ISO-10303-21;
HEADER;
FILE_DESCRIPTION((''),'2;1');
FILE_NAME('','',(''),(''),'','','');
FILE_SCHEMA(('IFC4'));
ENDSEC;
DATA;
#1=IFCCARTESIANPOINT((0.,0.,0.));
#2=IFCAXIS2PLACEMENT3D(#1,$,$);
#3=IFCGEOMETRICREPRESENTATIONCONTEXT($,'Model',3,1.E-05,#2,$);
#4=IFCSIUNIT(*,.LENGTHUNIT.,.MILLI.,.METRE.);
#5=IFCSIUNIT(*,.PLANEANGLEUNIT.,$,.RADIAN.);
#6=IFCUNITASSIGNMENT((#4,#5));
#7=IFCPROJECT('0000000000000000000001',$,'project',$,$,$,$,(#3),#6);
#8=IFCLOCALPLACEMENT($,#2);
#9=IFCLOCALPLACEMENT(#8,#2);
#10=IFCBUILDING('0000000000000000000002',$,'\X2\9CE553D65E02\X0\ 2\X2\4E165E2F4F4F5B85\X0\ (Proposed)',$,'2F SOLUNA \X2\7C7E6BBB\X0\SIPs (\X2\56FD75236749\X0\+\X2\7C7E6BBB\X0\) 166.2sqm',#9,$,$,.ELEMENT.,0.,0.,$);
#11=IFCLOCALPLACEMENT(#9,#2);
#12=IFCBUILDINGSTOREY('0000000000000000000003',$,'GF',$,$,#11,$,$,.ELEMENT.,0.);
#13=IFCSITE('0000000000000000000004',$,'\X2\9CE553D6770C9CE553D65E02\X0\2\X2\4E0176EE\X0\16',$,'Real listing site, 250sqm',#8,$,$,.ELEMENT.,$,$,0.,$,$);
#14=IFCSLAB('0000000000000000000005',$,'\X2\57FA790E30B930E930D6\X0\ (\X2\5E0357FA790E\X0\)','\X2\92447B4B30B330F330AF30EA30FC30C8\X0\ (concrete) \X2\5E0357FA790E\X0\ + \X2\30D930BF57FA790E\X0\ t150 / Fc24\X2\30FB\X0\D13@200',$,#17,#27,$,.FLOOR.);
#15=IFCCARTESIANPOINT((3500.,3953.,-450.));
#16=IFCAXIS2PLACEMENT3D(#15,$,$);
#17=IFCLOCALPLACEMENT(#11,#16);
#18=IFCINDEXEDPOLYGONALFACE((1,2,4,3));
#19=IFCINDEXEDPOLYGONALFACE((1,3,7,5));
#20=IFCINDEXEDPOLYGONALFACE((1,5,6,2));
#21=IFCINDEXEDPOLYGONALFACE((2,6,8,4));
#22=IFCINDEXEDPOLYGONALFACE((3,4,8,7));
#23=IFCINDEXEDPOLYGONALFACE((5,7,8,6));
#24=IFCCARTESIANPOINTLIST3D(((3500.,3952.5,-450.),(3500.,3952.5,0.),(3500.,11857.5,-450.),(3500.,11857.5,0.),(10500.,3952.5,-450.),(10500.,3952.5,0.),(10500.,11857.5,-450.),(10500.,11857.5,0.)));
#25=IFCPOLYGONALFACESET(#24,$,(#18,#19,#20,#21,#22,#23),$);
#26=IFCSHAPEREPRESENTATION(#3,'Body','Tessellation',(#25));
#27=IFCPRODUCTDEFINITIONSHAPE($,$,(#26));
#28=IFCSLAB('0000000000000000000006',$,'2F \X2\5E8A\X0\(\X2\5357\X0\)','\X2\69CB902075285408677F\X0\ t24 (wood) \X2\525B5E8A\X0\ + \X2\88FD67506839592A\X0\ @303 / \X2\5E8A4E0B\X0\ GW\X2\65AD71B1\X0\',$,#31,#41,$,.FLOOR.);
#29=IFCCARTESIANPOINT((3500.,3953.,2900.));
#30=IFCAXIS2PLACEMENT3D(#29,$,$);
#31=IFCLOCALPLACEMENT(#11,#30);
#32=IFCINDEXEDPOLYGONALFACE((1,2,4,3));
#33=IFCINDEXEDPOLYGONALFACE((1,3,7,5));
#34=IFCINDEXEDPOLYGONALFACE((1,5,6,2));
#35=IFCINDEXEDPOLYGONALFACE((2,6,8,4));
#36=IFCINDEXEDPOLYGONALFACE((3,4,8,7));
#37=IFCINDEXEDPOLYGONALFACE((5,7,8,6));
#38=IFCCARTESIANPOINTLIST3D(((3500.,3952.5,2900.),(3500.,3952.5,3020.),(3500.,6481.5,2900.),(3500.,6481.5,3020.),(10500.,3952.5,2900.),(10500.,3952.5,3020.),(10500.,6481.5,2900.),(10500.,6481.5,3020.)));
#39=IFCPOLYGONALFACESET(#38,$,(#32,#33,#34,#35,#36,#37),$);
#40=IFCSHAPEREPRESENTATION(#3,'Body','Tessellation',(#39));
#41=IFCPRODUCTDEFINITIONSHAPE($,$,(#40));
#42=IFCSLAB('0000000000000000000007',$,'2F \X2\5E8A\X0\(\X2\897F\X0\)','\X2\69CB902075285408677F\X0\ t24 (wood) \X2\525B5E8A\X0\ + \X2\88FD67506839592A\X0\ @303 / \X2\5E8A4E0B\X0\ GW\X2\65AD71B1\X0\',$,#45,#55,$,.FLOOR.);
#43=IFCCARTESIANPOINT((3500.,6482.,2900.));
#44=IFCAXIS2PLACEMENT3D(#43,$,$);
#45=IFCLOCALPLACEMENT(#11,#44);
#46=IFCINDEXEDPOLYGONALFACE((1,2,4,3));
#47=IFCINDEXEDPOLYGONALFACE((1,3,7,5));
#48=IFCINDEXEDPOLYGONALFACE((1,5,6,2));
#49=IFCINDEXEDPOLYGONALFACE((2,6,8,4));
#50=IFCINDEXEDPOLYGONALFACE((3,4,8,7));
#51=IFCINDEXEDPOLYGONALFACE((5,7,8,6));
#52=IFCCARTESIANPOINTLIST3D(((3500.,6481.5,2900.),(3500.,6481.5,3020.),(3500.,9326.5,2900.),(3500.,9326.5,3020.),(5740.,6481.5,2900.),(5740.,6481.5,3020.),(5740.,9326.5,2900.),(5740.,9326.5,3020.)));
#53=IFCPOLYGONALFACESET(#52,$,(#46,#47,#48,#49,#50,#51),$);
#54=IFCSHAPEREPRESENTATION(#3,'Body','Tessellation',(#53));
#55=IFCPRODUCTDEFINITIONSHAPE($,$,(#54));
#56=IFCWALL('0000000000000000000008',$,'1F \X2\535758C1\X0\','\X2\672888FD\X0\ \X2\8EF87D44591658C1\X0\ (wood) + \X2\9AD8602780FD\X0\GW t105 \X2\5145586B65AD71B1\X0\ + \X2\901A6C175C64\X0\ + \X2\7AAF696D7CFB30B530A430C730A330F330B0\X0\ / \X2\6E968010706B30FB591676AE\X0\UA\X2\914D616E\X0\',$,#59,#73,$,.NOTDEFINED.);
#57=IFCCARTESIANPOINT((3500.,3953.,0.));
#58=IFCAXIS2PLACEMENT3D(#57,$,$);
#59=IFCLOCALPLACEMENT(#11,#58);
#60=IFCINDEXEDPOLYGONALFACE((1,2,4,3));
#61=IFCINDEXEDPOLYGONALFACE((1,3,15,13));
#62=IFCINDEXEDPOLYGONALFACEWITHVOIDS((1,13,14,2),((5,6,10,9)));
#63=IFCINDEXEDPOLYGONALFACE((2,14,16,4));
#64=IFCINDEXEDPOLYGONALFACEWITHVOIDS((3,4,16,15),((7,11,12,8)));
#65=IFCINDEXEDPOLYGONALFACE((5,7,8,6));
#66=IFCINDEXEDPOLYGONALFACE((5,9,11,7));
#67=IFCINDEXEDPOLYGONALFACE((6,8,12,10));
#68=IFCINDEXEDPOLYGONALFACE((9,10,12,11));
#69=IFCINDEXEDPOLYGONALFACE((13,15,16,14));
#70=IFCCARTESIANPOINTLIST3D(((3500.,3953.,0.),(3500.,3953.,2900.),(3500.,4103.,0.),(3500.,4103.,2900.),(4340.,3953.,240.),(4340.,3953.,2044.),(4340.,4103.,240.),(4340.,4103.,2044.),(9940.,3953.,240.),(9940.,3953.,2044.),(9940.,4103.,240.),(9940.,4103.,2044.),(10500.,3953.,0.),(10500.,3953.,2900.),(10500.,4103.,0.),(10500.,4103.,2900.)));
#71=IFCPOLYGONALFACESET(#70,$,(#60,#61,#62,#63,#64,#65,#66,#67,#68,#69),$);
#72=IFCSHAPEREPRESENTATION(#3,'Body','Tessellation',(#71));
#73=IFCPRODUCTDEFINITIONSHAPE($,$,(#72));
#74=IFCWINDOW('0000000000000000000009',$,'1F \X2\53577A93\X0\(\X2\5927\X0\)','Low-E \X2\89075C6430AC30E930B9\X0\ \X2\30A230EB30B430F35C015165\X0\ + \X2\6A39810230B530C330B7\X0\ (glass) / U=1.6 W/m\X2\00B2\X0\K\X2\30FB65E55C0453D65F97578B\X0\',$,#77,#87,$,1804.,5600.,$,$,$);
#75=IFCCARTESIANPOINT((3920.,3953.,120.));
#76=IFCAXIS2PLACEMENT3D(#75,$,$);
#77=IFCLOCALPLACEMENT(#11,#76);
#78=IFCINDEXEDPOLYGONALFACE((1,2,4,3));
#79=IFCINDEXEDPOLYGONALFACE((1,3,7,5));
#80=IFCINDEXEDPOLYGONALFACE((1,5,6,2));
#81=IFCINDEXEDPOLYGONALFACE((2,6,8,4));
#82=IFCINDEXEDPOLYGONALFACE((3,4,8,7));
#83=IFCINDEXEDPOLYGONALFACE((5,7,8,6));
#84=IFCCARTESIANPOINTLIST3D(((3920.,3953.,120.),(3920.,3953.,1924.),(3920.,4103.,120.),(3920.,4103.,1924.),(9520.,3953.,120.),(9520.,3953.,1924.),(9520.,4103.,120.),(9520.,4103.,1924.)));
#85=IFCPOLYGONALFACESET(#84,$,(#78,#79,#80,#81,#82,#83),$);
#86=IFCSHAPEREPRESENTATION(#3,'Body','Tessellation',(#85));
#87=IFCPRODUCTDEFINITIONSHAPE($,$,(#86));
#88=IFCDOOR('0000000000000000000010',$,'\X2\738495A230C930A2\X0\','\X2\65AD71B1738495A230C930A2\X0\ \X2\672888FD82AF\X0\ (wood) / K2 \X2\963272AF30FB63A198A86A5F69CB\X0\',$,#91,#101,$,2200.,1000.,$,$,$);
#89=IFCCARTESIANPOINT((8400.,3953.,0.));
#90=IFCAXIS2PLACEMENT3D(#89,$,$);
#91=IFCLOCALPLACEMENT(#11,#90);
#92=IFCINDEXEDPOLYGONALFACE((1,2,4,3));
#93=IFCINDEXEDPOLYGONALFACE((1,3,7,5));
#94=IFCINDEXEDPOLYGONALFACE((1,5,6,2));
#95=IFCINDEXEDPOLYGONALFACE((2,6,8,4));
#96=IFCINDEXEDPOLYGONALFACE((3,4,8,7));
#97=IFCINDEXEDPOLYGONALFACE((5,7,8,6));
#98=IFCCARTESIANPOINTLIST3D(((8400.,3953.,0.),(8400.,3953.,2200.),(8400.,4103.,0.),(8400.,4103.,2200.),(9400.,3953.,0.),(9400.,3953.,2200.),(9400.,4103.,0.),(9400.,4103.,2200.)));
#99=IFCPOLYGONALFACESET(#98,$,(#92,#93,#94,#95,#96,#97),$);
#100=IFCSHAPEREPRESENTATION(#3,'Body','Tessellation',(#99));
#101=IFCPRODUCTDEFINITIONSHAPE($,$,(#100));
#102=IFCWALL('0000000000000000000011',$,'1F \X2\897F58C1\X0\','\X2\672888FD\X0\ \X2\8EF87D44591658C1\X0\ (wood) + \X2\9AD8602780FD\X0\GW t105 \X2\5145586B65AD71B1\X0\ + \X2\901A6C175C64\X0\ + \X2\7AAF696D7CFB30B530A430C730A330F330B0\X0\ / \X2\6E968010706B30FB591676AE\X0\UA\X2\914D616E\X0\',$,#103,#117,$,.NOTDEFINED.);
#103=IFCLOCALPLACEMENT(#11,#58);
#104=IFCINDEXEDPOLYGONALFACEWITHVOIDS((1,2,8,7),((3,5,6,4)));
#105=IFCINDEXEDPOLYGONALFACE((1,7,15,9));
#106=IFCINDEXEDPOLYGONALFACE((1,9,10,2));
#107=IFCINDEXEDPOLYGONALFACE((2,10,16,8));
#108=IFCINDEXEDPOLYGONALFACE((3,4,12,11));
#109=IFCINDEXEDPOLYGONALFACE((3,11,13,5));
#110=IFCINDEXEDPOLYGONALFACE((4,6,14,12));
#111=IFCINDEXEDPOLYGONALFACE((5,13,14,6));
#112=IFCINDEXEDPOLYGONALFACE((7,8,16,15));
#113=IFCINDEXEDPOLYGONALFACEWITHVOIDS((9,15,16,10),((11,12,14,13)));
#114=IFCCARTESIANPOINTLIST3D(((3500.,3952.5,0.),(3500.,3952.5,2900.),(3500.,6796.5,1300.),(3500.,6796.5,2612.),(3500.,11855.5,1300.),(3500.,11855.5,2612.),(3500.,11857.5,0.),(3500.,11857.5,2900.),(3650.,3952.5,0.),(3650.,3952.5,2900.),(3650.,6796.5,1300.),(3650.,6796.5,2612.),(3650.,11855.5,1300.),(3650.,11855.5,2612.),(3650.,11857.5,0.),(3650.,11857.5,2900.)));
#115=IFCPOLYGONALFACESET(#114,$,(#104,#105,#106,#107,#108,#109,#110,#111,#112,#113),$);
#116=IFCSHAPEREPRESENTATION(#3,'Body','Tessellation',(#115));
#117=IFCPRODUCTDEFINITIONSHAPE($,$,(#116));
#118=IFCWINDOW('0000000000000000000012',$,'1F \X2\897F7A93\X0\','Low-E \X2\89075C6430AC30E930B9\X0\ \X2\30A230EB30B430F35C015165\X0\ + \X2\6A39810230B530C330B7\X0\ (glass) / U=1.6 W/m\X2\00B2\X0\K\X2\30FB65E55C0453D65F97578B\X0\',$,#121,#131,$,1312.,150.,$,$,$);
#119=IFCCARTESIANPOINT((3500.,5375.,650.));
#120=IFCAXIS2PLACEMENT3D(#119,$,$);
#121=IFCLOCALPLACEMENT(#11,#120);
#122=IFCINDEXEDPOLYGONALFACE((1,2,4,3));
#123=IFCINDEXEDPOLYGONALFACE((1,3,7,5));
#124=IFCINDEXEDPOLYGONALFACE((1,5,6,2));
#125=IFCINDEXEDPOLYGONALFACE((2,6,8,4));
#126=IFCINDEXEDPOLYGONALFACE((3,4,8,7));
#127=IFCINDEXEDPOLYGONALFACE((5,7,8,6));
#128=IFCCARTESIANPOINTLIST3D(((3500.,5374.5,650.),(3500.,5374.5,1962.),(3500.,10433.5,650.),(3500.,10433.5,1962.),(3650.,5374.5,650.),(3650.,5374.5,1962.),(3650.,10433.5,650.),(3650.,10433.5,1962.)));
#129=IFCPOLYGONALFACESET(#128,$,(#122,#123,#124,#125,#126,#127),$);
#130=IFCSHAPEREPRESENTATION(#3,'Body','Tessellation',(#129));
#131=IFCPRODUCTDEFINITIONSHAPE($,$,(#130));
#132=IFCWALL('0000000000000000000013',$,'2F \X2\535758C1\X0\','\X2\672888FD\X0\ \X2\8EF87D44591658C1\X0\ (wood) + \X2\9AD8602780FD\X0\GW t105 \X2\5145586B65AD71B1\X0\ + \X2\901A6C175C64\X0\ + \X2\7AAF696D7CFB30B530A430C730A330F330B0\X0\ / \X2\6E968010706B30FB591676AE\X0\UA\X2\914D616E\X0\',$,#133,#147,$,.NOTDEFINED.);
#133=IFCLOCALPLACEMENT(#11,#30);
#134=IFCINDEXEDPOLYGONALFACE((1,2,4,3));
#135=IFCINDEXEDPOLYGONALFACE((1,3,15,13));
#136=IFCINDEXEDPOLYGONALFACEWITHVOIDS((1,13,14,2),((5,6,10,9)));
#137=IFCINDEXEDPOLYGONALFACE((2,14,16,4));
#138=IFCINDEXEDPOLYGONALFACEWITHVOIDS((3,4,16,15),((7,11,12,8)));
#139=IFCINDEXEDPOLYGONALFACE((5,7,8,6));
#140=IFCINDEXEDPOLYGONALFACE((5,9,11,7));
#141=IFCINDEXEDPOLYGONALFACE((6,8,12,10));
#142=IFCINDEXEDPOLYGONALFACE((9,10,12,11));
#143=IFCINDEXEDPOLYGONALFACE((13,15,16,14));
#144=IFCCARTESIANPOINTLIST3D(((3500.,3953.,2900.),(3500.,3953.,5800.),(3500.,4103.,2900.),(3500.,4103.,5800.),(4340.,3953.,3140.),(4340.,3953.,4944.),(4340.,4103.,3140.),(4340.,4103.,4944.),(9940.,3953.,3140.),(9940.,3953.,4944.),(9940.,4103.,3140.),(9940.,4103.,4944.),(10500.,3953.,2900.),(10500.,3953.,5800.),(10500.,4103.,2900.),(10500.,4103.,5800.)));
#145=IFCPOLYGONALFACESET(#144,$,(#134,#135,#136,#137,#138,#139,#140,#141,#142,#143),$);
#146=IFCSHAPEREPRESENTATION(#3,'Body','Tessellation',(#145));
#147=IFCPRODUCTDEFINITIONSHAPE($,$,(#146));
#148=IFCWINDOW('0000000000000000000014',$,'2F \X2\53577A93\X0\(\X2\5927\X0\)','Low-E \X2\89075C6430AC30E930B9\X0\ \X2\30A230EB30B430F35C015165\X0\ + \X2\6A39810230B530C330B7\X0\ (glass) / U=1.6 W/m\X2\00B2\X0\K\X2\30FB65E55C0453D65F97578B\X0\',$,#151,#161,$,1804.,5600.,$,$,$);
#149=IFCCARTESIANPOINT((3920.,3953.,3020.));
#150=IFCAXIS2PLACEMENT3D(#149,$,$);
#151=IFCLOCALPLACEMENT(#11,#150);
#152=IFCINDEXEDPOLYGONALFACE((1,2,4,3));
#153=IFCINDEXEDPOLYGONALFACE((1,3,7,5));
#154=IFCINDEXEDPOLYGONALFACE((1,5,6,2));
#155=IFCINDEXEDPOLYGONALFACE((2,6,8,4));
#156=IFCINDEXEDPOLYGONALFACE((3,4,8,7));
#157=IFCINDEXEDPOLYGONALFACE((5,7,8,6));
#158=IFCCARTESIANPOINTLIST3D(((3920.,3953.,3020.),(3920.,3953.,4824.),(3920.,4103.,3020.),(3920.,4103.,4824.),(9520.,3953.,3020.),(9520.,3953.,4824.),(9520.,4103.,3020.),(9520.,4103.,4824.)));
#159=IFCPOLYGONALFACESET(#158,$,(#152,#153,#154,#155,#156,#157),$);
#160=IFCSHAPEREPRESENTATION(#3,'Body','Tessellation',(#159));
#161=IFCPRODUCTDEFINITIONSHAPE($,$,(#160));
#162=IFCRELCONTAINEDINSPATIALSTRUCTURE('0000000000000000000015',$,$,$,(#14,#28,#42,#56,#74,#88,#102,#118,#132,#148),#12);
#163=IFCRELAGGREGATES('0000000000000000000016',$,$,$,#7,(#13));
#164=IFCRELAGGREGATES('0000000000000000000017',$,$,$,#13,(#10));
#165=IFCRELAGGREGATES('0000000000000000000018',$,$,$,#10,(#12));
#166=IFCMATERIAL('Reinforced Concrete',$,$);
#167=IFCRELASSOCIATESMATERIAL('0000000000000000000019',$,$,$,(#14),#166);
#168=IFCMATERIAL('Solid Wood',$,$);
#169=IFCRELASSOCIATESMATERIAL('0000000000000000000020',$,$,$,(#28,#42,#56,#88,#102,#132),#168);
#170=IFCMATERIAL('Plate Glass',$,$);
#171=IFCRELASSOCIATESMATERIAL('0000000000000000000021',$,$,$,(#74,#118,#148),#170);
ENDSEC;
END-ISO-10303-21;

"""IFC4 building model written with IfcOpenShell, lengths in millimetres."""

from ifc_helpers import new_model, si_unit, frame, frame_2d, origin, place, context, project, spatial, rectangle, extrude, material, element, fill, save


model = new_model("IFC4")

# Units and contexts
model_context = context("Model", 3, precision=1e-05, world=origin())
ifc_project = project(units=[si_unit("LENGTHUNIT", "METRE", prefix="MILLI"), si_unit("PLANEANGLEUNIT", "RADIAN")], contexts=[model_context])

# Site, building, storey
site_placement = place(None, origin())
site = spatial("IfcSite", under=ifc_project, at=site_placement, Name="鳥取県鳥取市2丁目16", ObjectType="Real listing site, 250sqm", CompositionType="ELEMENT", RefElevation=0.0)
building_placement = place(site_placement, origin())
building = spatial("IfcBuilding", under=site, at=building_placement, Name="鳥取市 2世帯住宅 (Proposed)", ObjectType="2F SOLUNA 籾殻SIPs (国産杉+籾殻) 166.2sqm", CompositionType="ELEMENT", ElevationOfRefHeight=0.0, ElevationOfTerrain=0.0)
storey_placement = place(building_placement, origin())
storey = spatial("IfcBuildingStorey", under=building, at=storey_placement, Name="GF", CompositionType="ELEMENT", Elevation=0.0)

# Slabs
ifc_material_1 = material(Name="Reinforced Concrete")
slab_1_placement = place(storey_placement, frame((3500.0, 3953.0, -450.0)))
element("IfcSlab", 1, at=slab_1_placement, inside=storey, material=ifc_material_1, Name="基礎スラブ (布基礎)", Description="鉄筋コンクリート (concrete) 布基礎 + ベタ基礎 t150 / Fc24・D13@200", PredefinedType="FLOOR", context=model_context, shape_type="SweptSolid", body=[
    extrude(rectangle(XDim=7000.0, YDim=7905.0, at=frame_2d((3500.0, 3952.0))), frame((3500.0, 3953.0, -450.0)), (0.0, 0.0, 1.0), 450.0),
])
ifc_material_2 = material(Name="Solid Wood")
slab_2_placement = place(storey_placement, frame((3500.0, 3953.0, 2900.0)))
element("IfcSlab", 2, at=slab_2_placement, inside=storey, material=ifc_material_2, Name="2F 床(南)", Description="構造用合板 t24 (wood) 剛床 + 製材根太 @303 / 床下 GW断熱", PredefinedType="FLOOR", context=model_context, shape_type="SweptSolid", body=[
    extrude(rectangle(XDim=7000.0, YDim=2529.0, at=frame_2d((3500.0, 1264.0))), frame((3500.0, 3953.0, 2900.0)), (0.0, 0.0, 1.0), 120.0),
])
slab_3_placement = place(storey_placement, frame((3500.0, 6482.0, 2900.0)))
element("IfcSlab", 3, at=slab_3_placement, inside=storey, material=ifc_material_2, Name="2F 床(西)", Description="構造用合板 t24 (wood) 剛床 + 製材根太 @303 / 床下 GW断熱", PredefinedType="FLOOR", context=model_context, shape_type="SweptSolid", body=[
    extrude(rectangle(XDim=2240.0, YDim=2845.0, at=frame_2d((1120.0, 1422.0))), frame((3500.0, 6482.0, 2900.0)), (0.0, 0.0, 1.0), 120.0),
])

# Wall, openings, window, door
wall_1_placement = place(storey_placement, frame((3500.0, 3953.0, 0.0)))
wall_1 = element("IfcWall", 4, at=wall_1_placement, inside=storey, material=ifc_material_2, Name="1F 南壁", Description="木製 軸組外壁 (wood) + 高性能GW t105 充填断熱 + 通気層 + 窯業系サイディング / 準耐火・外皮UA配慮", PredefinedType="NOTDEFINED", context=model_context, shape_type="SweptSolid", body=[
    extrude(rectangle(XDim=7000.0, YDim=150.0, at=frame_2d((3500.0, 75.0))), frame((3500.0, 3953.0, 0.0)), (0.0, 0.0, 1.0), 2900.0),
])
opening_1_placement = place(storey_placement, frame((3920.0, 3953.0, 120.0)))
opening_1 = element("IfcOpeningElement", 5, at=opening_1_placement, cuts=wall_1, PredefinedType="NOTDEFINED", context=model_context, shape_type="SweptSolid", body=[
    extrude(rectangle(XDim=5600.0, YDim=150.0, at=frame_2d((2800.0, 75.0))), frame((3920.0, 3953.0, 120.0)), (0.0, 0.0, 1.0), 1804.0),
])
opening_2_placement = place(storey_placement, frame((8400.0, 3953.0, 0.0)))
opening_2 = element("IfcOpeningElement", 6, at=opening_2_placement, cuts=wall_1, PredefinedType="NOTDEFINED", context=model_context, shape_type="SweptSolid", body=[
    extrude(rectangle(XDim=1000.0, YDim=150.0, at=frame_2d((500.0, 75.0))), frame((8400.0, 3953.0, 0.0)), (0.0, 0.0, 1.0), 2200.0),
])
ifc_material_3 = material(Name="Plate Glass")
window_1_placement = place(storey_placement, frame((3920.0, 3953.0, 120.0)))
window_1 = element("IfcWindow", 7, at=window_1_placement, inside=storey, material=ifc_material_3, Name="1F 南窓(大)", Description="Low-E 複層ガラス アルゴン封入 + 樹脂サッシ (glass) / U=1.6 W/m²K・日射取得型", OverallHeight=1804.0, OverallWidth=5600.0, context=model_context, shape_type="SweptSolid", body=[
    extrude(rectangle(XDim=5600.0, YDim=150.0, at=frame_2d((2800.0, 75.0))), frame((3920.0, 3953.0, 120.0)), (0.0, 0.0, 1.0), 1804.0),
])
fill(opening_1, window_1)
door_placement = place(storey_placement, frame((8400.0, 3953.0, 0.0)))
door = element("IfcDoor", 8, at=door_placement, inside=storey, material=ifc_material_2, Name="玄関ドア", Description="断熱玄関ドア 木製芯 (wood) / K2 防犯・採風機構", OverallHeight=2200.0, OverallWidth=1000.0, context=model_context, shape_type="SweptSolid", body=[
    extrude(rectangle(XDim=1000.0, YDim=150.0, at=frame_2d((500.0, 75.0))), frame((8400.0, 3953.0, 0.0)), (0.0, 0.0, 1.0), 2200.0),
])
fill(opening_2, door)

# Walls, openings, windows
wall_2_placement = place(storey_placement, frame((3500.0, 3953.0, 0.0)))
wall_2 = element("IfcWall", 9, at=wall_2_placement, inside=storey, material=ifc_material_2, Name="1F 西壁", Description="木製 軸組外壁 (wood) + 高性能GW t105 充填断熱 + 通気層 + 窯業系サイディング / 準耐火・外皮UA配慮", PredefinedType="NOTDEFINED", context=model_context, shape_type="SweptSolid", body=[
    extrude(rectangle(XDim=150.0, YDim=7905.0, at=frame_2d((75.0, 3952.0))), frame((3500.0, 3953.0, 0.0)), (0.0, 0.0, 1.0), 2900.0),
])
opening_3_placement = place(storey_placement, frame((3500.0, 5375.0, 650.0)))
opening_3 = element("IfcOpeningElement", 10, at=opening_3_placement, cuts=wall_2, PredefinedType="NOTDEFINED", context=model_context, shape_type="SweptSolid", body=[
    extrude(rectangle(XDim=150.0, YDim=5059.0, at=frame_2d((75.0, 2529.0))), frame((3500.0, 5375.0, 650.0)), (0.0, 0.0, 1.0), 1312.0),
])
window_2_placement = place(storey_placement, frame((3500.0, 5375.0, 650.0)))
window_2 = element("IfcWindow", 11, at=window_2_placement, inside=storey, material=ifc_material_3, Name="1F 西窓", Description="Low-E 複層ガラス アルゴン封入 + 樹脂サッシ (glass) / U=1.6 W/m²K・日射取得型", OverallHeight=1312.0, OverallWidth=150.0, context=model_context, shape_type="SweptSolid", body=[
    extrude(rectangle(XDim=150.0, YDim=5059.0, at=frame_2d((75.0, 2529.0))), frame((3500.0, 5375.0, 650.0)), (0.0, 0.0, 1.0), 1312.0),
])
fill(opening_3, window_2)
wall_3_placement = place(storey_placement, frame((3500.0, 3953.0, 2900.0)))
wall_3 = element("IfcWall", 12, at=wall_3_placement, inside=storey, material=ifc_material_2, Name="2F 南壁", Description="木製 軸組外壁 (wood) + 高性能GW t105 充填断熱 + 通気層 + 窯業系サイディング / 準耐火・外皮UA配慮", PredefinedType="NOTDEFINED", context=model_context, shape_type="SweptSolid", body=[
    extrude(rectangle(XDim=7000.0, YDim=150.0, at=frame_2d((3500.0, 75.0))), frame((3500.0, 3953.0, 2900.0)), (0.0, 0.0, 1.0), 2900.0),
])
opening_4_placement = place(storey_placement, frame((3920.0, 3953.0, 3020.0)))
opening_4 = element("IfcOpeningElement", 13, at=opening_4_placement, cuts=wall_3, PredefinedType="NOTDEFINED", context=model_context, shape_type="SweptSolid", body=[
    extrude(rectangle(XDim=5600.0, YDim=150.0, at=frame_2d((2800.0, 75.0))), frame((3920.0, 3953.0, 3020.0)), (0.0, 0.0, 1.0), 1804.0),
])
window_3_placement = place(storey_placement, frame((3920.0, 3953.0, 3020.0)))
window_3 = element("IfcWindow", 14, at=window_3_placement, inside=storey, material=ifc_material_3, Name="2F 南窓(大)", Description="Low-E 複層ガラス アルゴン封入 + 樹脂サッシ (glass) / U=1.6 W/m²K・日射取得型", OverallHeight=1804.0, OverallWidth=5600.0, context=model_context, shape_type="SweptSolid", body=[
    extrude(rectangle(XDim=5600.0, YDim=150.0, at=frame_2d((2800.0, 75.0))), frame((3920.0, 3953.0, 3020.0)), (0.0, 0.0, 1.0), 1804.0),
])
fill(opening_4, window_3)

save(model, "model.ifc")
